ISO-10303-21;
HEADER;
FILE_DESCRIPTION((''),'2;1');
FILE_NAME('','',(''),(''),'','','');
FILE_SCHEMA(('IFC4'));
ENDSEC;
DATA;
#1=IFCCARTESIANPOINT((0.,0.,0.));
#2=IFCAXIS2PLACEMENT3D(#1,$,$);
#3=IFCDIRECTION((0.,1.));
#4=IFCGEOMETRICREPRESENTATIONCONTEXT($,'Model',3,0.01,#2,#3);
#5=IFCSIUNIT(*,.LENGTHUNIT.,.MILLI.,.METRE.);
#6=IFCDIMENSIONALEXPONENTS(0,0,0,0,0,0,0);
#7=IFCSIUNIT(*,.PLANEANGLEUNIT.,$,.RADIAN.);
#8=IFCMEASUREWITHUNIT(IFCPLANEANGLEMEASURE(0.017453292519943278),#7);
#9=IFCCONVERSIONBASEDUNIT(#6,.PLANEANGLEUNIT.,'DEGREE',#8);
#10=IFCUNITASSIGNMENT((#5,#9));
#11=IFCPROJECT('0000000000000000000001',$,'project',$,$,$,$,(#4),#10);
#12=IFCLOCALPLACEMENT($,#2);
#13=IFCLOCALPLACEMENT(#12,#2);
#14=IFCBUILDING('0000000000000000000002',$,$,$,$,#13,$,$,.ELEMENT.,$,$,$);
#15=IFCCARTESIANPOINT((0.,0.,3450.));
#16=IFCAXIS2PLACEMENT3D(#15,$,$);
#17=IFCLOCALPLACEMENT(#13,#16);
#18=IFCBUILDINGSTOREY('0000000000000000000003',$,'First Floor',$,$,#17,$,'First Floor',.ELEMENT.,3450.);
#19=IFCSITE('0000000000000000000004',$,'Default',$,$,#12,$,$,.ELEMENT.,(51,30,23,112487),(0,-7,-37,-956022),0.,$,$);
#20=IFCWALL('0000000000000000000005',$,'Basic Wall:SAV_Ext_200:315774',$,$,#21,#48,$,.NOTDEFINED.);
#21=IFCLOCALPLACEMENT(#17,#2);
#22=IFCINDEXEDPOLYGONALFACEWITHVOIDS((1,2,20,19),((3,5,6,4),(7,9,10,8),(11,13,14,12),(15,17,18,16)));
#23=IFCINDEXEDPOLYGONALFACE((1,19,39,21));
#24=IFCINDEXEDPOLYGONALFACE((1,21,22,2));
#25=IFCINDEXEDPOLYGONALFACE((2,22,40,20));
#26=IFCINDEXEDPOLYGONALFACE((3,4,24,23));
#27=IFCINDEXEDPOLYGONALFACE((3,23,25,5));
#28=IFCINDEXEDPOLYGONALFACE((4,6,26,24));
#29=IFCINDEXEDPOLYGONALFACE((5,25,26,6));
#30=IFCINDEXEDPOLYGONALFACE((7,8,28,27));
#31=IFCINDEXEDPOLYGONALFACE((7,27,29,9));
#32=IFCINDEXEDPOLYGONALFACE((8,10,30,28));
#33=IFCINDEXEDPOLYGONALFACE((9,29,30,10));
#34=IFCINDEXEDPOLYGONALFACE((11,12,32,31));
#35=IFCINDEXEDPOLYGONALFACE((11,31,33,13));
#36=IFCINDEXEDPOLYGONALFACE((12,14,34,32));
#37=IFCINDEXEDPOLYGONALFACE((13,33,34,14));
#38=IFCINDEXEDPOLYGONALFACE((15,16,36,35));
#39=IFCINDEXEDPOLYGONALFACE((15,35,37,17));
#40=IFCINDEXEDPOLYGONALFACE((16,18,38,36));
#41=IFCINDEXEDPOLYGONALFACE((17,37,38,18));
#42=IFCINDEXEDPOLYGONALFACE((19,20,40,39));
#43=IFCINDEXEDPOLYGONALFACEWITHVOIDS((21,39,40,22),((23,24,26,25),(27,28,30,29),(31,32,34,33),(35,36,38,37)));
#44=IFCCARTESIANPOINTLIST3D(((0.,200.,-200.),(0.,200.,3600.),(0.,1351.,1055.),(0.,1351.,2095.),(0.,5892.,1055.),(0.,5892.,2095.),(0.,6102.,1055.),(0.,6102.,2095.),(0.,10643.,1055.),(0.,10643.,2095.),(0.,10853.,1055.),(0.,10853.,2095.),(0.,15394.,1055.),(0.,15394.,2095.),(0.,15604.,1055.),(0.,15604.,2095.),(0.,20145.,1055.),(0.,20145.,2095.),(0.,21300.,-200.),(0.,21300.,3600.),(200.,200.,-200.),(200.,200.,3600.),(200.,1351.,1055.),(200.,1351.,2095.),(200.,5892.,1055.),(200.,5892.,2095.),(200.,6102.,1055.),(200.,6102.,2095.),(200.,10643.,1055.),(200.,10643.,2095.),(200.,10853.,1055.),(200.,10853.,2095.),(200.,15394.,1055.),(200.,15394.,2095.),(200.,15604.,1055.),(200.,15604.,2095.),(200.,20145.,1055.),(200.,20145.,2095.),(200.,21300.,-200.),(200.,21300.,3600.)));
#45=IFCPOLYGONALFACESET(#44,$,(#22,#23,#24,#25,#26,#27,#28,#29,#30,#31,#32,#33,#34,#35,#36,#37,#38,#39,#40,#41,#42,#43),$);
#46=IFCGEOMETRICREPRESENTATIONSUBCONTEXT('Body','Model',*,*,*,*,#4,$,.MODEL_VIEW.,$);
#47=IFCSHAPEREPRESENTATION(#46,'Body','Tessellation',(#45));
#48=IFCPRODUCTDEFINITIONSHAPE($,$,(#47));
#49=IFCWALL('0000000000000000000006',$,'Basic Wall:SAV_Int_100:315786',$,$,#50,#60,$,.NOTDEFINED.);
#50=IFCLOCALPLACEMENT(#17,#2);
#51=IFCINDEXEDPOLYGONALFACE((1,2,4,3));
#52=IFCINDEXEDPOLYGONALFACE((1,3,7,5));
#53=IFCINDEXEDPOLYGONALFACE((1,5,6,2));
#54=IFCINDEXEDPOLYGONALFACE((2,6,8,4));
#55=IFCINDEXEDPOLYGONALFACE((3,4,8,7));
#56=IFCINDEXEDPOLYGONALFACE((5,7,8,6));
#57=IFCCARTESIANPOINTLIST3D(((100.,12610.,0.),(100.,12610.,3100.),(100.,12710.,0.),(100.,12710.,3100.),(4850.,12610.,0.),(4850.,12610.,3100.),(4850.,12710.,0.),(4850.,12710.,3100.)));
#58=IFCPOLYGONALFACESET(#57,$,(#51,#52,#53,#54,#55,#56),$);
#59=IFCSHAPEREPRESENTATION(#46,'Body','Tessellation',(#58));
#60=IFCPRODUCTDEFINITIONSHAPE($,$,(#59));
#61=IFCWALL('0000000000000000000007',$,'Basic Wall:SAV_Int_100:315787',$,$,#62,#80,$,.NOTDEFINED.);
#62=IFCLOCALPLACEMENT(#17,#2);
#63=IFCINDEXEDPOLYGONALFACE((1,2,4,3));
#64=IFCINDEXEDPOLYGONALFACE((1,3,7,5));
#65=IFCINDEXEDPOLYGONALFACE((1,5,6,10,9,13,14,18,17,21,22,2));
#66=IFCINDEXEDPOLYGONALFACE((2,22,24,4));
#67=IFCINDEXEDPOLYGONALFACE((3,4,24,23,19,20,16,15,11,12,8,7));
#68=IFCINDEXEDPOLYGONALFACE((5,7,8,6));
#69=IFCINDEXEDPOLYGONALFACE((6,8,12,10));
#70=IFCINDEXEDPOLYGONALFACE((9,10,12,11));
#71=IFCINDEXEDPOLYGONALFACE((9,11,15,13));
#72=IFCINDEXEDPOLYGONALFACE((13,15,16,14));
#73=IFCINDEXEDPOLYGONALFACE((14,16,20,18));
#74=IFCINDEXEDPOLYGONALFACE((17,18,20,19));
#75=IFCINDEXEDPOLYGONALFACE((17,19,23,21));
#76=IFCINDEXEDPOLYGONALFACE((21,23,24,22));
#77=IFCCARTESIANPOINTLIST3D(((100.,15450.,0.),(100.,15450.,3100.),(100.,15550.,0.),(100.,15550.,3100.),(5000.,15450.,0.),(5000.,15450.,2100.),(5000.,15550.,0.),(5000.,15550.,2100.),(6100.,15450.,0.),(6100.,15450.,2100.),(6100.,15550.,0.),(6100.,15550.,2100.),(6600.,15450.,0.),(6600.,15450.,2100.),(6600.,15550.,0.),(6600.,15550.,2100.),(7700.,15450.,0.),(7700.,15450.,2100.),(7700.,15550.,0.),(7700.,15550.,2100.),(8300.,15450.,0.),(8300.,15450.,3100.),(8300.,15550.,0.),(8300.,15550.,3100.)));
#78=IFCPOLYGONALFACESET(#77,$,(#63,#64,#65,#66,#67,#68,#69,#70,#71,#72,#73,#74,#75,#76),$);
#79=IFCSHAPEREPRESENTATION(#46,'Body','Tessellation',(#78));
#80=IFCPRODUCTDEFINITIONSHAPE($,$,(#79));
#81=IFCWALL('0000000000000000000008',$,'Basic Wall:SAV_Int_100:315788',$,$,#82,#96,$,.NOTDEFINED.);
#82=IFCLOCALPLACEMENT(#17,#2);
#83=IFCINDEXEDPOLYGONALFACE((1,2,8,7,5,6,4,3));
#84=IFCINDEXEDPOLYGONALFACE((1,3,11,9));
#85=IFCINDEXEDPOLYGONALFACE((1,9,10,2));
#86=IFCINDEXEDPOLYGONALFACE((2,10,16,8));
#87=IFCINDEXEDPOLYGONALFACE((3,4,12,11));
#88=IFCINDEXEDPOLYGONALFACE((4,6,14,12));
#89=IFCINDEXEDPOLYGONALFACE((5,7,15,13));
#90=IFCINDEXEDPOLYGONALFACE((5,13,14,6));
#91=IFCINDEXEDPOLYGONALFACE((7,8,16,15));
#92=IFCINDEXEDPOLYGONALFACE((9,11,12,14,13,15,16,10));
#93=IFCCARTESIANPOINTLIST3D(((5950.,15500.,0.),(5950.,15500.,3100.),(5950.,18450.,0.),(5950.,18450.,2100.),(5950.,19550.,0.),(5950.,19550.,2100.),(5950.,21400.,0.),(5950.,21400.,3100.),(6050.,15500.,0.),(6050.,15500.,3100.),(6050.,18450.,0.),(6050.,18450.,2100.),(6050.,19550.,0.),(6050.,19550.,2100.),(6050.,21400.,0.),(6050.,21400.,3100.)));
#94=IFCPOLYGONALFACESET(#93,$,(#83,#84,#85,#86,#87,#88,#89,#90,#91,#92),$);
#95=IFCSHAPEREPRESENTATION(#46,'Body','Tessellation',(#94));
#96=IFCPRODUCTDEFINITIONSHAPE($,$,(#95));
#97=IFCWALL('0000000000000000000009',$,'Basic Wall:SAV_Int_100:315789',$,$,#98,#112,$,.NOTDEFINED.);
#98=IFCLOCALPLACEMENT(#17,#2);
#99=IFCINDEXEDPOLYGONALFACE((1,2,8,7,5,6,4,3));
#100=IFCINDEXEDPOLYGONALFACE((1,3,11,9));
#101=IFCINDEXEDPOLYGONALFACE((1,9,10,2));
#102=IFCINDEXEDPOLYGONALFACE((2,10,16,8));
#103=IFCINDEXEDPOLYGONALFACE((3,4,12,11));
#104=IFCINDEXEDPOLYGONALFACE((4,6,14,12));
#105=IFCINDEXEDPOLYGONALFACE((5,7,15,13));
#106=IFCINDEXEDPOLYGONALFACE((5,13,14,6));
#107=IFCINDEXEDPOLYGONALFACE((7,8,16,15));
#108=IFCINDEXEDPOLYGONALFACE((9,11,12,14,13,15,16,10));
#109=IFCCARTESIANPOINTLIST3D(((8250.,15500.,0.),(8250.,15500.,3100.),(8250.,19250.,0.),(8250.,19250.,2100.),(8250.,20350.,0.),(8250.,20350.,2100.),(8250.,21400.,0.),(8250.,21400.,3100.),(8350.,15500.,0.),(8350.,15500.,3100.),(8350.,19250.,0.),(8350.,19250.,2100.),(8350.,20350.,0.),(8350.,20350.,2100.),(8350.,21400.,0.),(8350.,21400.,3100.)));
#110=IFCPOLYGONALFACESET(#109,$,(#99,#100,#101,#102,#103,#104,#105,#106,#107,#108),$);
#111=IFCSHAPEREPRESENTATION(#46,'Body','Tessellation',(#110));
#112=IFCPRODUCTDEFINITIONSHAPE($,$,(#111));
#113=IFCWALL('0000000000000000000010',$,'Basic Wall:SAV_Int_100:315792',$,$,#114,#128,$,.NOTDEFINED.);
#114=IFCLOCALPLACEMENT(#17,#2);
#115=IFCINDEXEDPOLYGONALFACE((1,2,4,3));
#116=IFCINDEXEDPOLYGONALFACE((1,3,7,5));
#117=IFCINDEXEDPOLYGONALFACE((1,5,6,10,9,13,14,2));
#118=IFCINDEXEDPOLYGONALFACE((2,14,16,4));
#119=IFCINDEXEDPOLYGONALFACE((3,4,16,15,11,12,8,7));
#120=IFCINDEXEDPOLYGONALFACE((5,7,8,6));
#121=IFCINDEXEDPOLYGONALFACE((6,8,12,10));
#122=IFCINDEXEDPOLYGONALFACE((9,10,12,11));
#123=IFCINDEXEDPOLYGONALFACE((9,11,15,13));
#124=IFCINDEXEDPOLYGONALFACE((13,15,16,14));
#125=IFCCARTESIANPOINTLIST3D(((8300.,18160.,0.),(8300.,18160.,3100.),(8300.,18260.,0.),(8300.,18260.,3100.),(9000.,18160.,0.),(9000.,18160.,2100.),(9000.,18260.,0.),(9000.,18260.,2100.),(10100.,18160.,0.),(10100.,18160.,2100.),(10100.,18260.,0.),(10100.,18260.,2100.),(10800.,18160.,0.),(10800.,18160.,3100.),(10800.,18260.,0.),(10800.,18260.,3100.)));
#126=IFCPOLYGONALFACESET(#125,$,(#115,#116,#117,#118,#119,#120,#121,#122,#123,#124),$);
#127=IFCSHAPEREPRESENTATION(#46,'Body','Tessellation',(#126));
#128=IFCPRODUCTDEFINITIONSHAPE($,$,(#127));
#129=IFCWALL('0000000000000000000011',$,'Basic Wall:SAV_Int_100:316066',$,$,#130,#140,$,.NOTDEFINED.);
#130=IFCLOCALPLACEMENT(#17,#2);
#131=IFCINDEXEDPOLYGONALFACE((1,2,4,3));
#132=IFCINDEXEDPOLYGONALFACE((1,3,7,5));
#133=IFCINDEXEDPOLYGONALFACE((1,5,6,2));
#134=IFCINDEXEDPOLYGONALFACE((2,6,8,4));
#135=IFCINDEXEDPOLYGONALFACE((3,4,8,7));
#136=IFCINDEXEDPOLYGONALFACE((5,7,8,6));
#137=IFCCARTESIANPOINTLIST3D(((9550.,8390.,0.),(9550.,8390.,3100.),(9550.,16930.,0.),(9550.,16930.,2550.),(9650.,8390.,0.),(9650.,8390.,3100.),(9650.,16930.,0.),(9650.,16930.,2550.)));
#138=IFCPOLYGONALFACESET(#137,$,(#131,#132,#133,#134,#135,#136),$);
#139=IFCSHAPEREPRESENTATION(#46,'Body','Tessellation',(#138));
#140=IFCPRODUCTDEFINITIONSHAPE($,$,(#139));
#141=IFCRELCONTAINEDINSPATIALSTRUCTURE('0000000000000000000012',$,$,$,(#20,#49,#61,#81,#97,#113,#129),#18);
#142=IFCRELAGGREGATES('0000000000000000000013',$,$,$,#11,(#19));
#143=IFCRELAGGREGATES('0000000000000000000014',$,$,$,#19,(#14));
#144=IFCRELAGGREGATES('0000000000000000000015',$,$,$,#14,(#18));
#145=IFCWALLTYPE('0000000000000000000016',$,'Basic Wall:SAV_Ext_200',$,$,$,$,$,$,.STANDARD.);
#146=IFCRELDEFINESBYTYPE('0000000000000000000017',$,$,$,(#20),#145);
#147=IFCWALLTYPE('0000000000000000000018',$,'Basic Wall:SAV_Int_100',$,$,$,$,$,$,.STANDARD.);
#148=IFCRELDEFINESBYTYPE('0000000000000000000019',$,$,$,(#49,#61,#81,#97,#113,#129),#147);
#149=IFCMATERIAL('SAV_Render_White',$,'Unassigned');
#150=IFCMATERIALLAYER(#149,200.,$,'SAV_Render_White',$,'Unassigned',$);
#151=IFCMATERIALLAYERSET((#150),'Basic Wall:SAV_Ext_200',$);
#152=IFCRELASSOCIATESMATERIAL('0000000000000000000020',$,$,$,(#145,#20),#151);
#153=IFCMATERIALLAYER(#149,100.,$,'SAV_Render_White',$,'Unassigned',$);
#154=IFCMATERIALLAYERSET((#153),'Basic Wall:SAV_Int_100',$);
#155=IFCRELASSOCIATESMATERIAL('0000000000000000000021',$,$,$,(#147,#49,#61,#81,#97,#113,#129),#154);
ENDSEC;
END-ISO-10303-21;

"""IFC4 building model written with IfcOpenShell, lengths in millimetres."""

from ifc_helpers import new_model, entity, si_unit, converted_unit, direction, frame, frame_2d, origin, place, context, subcontext, project, spatial, rectangle, extrude, clip, halfspace, material, layer, layer_set, layer_usage, type_object, element, save


model = new_model("IFC4")

# Units and contexts
model_context = context("Model", 3, precision=0.01, world=origin(), true_north=direction((0.0, 1.0)))
body_context = subcontext(model_context, "Body", "Model", "MODEL_VIEW")
ifc_project = project(units=[si_unit("LENGTHUNIT", "METRE", prefix="MILLI"), converted_unit("PLANEANGLEUNIT", "DEGREE", entity("IfcPlaneAngleMeasure", 0.017453292519943278), si_unit("PLANEANGLEUNIT", "RADIAN"), dimensions=[0, 0, 0, 0, 0, 0, 0])], contexts=[model_context])

# Site, building, storey
site_placement = place(None, origin())
site = spatial("IfcSite", under=ifc_project, at=site_placement, Name="Default", CompositionType="ELEMENT", RefLatitude=(51, 30, 23, 112487), RefLongitude=(0, -7, -37, -956022), RefElevation=0.0)
building_placement = place(site_placement, origin())
building = spatial("IfcBuilding", under=site, at=building_placement, CompositionType="ELEMENT")
storey_placement = place(building_placement, frame((0.0, 0.0, 3450.0)))
storey = spatial("IfcBuildingStorey", under=building, at=storey_placement, Name="First Floor", LongName="First Floor", CompositionType="ELEMENT", Elevation=3450.0)

# Wall, openings
ifc_material_1 = material(Name="SAV_Render_White", Category="Unassigned")
ifc_layer_1 = layer(ifc_material_1, 200.0, Name="SAV_Render_White", Category="Unassigned")
ifc_layer_set_1 = layer_set([ifc_layer_1], Name="Basic Wall:SAV_Ext_200")
ifc_layer_usage_1 = layer_usage(ifc_layer_set_1, "AXIS2", "NEGATIVE", 100.0)
wall_type_1 = type_object("IfcWallType", Name="Basic Wall:SAV_Ext_200", PredefinedType="STANDARD", material=ifc_layer_set_1)
wall_1_placement = place(storey_placement, frame((100.0, 21300.0, -200.0), z_axis=(0.0, 0.0, 1.0), x_axis=(0.0, -1.0, 0.0)))
wall_1 = element("IfcWall", 1, at=wall_1_placement, inside=storey, type_object=wall_type_1, material=ifc_layer_usage_1, Name="Basic Wall:SAV_Ext_200:315774", PredefinedType="NOTDEFINED", context=body_context, shape_type="SweptSolid", body=[
    extrude(rectangle(XDim=21100.0, YDim=200.0, at=frame_2d((10550.0, 0.0), x_axis=(-1.0, 0.0))), origin(), (0.0, 0.0, 1.0), 3800.0),
])
opening_1_placement = place(wall_1_placement, frame((15408.0, -100.0, 1255.0)))
element("IfcOpeningElement", 2, at=opening_1_placement, cuts=wall_1, PredefinedType="OPENING", context=body_context, shape_type="SweptSolid", body=[
    extrude(rectangle(XDim=1040.0, YDim=4541.0, at=frame_2d((520.0, 2270.5), x_axis=(-1.0, 0.0))), frame((0.0, 0.0, 0.0), z_axis=(0.0, 1.0, 0.0), x_axis=(0.0, 0.0, 1.0)), (0.0, 0.0, 1.0), 200.0),
])
opening_2_placement = place(wall_1_placement, frame((10657.0, -100.0, 1255.0)))
element("IfcOpeningElement", 3, at=opening_2_placement, cuts=wall_1, PredefinedType="OPENING", context=body_context, shape_type="SweptSolid", body=[
    extrude(rectangle(XDim=1040.0, YDim=4541.0, at=frame_2d((520.0, 2270.5), x_axis=(-1.0, 0.0))), frame((0.0, 0.0, 0.0), z_axis=(0.0, 1.0, 0.0), x_axis=(0.0, 0.0, 1.0)), (0.0, 0.0, 1.0), 200.0),
])
opening_3_placement = place(wall_1_placement, frame((5906.0, -100.0, 1255.0)))
element("IfcOpeningElement", 4, at=opening_3_placement, cuts=wall_1, PredefinedType="OPENING", context=body_context, shape_type="SweptSolid", body=[
    extrude(rectangle(XDim=1040.0, YDim=4541.0, at=frame_2d((520.0, 2270.5), x_axis=(-1.0, 0.0))), frame((0.0, 0.0, 0.0), z_axis=(0.0, 1.0, 0.0), x_axis=(0.0, 0.0, 1.0)), (0.0, 0.0, 1.0), 200.0),
])
opening_4_placement = place(wall_1_placement, frame((1155.0, -100.0, 1255.0)))
element("IfcOpeningElement", 5, at=opening_4_placement, cuts=wall_1, PredefinedType="OPENING", context=body_context, shape_type="SweptSolid", body=[
    extrude(rectangle(XDim=1040.0, YDim=4541.0, at=frame_2d((520.0, 2270.5), x_axis=(-1.0, 0.0))), frame((0.0, 0.0, 0.0), z_axis=(0.0, 1.0, 0.0), x_axis=(0.0, 0.0, 1.0)), (0.0, 0.0, 1.0), 200.0),
])

# Wall
ifc_layer_2 = layer(ifc_material_1, 100.0, Name="SAV_Render_White", Category="Unassigned")
ifc_layer_set_2 = layer_set([ifc_layer_2], Name="Basic Wall:SAV_Int_100")
ifc_layer_usage_2 = layer_usage(ifc_layer_set_2, "AXIS2", "NEGATIVE", 50.0)
wall_type_2 = type_object("IfcWallType", Name="Basic Wall:SAV_Int_100", PredefinedType="STANDARD", material=ifc_layer_set_2)
wall_2_placement = place(storey_placement, frame((100.0, 12660.0, 0.0)))
element("IfcWall", 6, at=wall_2_placement, inside=storey, type_object=wall_type_2, material=ifc_layer_usage_2, Name="Basic Wall:SAV_Int_100:315786", PredefinedType="NOTDEFINED", context=body_context, shape_type="SweptSolid", body=[
    extrude(rectangle(XDim=4750.0, YDim=100.0, at=frame_2d((2375.0, 0.0), x_axis=(-1.0, 0.0))), origin(), (0.0, 0.0, 1.0), 3100.0),
])

# Wall, openings
ifc_layer_usage_3 = layer_usage(ifc_layer_set_2, "AXIS2", "NEGATIVE", 50.0)
wall_3_placement = place(storey_placement, frame((100.0, 15500.0, 0.0)))
wall_3 = element("IfcWall", 7, at=wall_3_placement, inside=storey, type_object=wall_type_2, material=ifc_layer_usage_3, Name="Basic Wall:SAV_Int_100:315787", PredefinedType="NOTDEFINED", context=body_context, shape_type="SweptSolid", body=[
    extrude(rectangle(XDim=8200.0, YDim=100.0, at=frame_2d((4100.0, 0.0), x_axis=(-1.0, 0.0))), origin(), (0.0, 0.0, 1.0), 3100.0),
])
opening_5_placement = place(wall_3_placement, frame((6500.0, -50.0, 0.0)))
element("IfcOpeningElement", 8, at=opening_5_placement, cuts=wall_3, PredefinedType="OPENING", context=body_context, shape_type="SweptSolid", body=[
    extrude(rectangle(XDim=2100.0, YDim=1100.0, at=frame_2d((1050.0, 550.0), x_axis=(1.0, 0.0))), frame((0.0, 0.0, 0.0), z_axis=(0.0, 1.0, 0.0), x_axis=(0.0, 0.0, 1.0)), (0.0, 0.0, 1.0), 100.0),
])
opening_6_placement = place(wall_3_placement, frame((4900.0, -50.0, 0.0)))
element("IfcOpeningElement", 9, at=opening_6_placement, cuts=wall_3, PredefinedType="OPENING", context=body_context, shape_type="SweptSolid", body=[
    extrude(rectangle(XDim=2100.0, YDim=1100.0, at=frame_2d((1050.0, 550.0), x_axis=(1.0, 0.0))), frame((0.0, 0.0, 0.0), z_axis=(0.0, 1.0, 0.0), x_axis=(0.0, 0.0, 1.0)), (0.0, 0.0, 1.0), 100.0),
])

# Walls, openings
ifc_layer_usage_4 = layer_usage(ifc_layer_set_2, "AXIS2", "NEGATIVE", 50.0)
wall_4_placement = place(storey_placement, frame((6000.0, 15500.0, 0.0), z_axis=(0.0, 0.0, 1.0), x_axis=(0.0, 1.0, 0.0)))
wall_4 = element("IfcWall", 10, at=wall_4_placement, inside=storey, type_object=wall_type_2, material=ifc_layer_usage_4, Name="Basic Wall:SAV_Int_100:315788", PredefinedType="NOTDEFINED", context=body_context, shape_type="SweptSolid", body=[
    extrude(rectangle(XDim=5900.0, YDim=100.0, at=frame_2d((2950.0, 0.0), x_axis=(1.0, 0.0))), origin(), (0.0, 0.0, 1.0), 3100.0),
])
opening_7_placement = place(wall_4_placement, frame((2950.0, -50.0, 0.0)))
element("IfcOpeningElement", 11, at=opening_7_placement, cuts=wall_4, PredefinedType="OPENING", context=body_context, shape_type="SweptSolid", body=[
    extrude(rectangle(XDim=2100.0, YDim=1100.0, at=frame_2d((1050.0, 550.0), x_axis=(1.0, 0.0))), frame((0.0, 0.0, 0.0), z_axis=(0.0, 1.0, 0.0), x_axis=(0.0, 0.0, 1.0)), (0.0, 0.0, 1.0), 100.0),
])
ifc_layer_usage_5 = layer_usage(ifc_layer_set_2, "AXIS2", "NEGATIVE", 50.0)
wall_5_placement = place(storey_placement, frame((8300.0, 15500.0, 0.0), z_axis=(0.0, 0.0, 1.0), x_axis=(0.0, 1.0, 0.0)))
wall_5 = element("IfcWall", 12, at=wall_5_placement, inside=storey, type_object=wall_type_2, material=ifc_layer_usage_5, Name="Basic Wall:SAV_Int_100:315789", PredefinedType="NOTDEFINED", context=body_context, shape_type="SweptSolid", body=[
    extrude(rectangle(XDim=5900.0, YDim=100.0, at=frame_2d((2950.0, 0.0), x_axis=(1.0, 0.0))), origin(), (0.0, 0.0, 1.0), 3100.0),
])
opening_8_placement = place(wall_5_placement, frame((3750.0, -50.0, 0.0)))
element("IfcOpeningElement", 13, at=opening_8_placement, cuts=wall_5, PredefinedType="OPENING", context=body_context, shape_type="SweptSolid", body=[
    extrude(rectangle(XDim=2100.0, YDim=1100.0, at=frame_2d((1050.0, 550.0), x_axis=(1.0, 0.0))), frame((0.0, 0.0, 0.0), z_axis=(0.0, 1.0, 0.0), x_axis=(0.0, 0.0, 1.0)), (0.0, 0.0, 1.0), 100.0),
])
ifc_layer_usage_6 = layer_usage(ifc_layer_set_2, "AXIS2", "NEGATIVE", 50.0)
wall_6_placement = place(storey_placement, frame((8300.0, 18210.0, 0.0)))
wall_6 = element("IfcWall", 14, at=wall_6_placement, inside=storey, type_object=wall_type_2, material=ifc_layer_usage_6, Name="Basic Wall:SAV_Int_100:315792", PredefinedType="NOTDEFINED", context=body_context, shape_type="SweptSolid", body=[
    extrude(rectangle(XDim=2500.0, YDim=100.0, at=frame_2d((1250.0, 0.0), x_axis=(1.0, 0.0))), origin(), (0.0, 0.0, 1.0), 3100.0),
])
opening_9_placement = place(wall_6_placement, frame((700.0, -50.0, 0.0)))
element("IfcOpeningElement", 15, at=opening_9_placement, cuts=wall_6, PredefinedType="OPENING", context=body_context, shape_type="SweptSolid", body=[
    extrude(rectangle(XDim=2100.0, YDim=1100.0, at=frame_2d((1050.0, 550.0), x_axis=(1.0, 0.0))), frame((0.0, 0.0, 0.0), z_axis=(0.0, 1.0, 0.0), x_axis=(0.0, 0.0, 1.0)), (0.0, 0.0, 1.0), 100.0),
])

# Wall
ifc_layer_usage_7 = layer_usage(ifc_layer_set_2, "AXIS2", "POSITIVE", -50.0)
wall_7_placement = place(storey_placement, frame((9600.0, 8390.0, 0.0), z_axis=(0.0, 0.0, 1.0), x_axis=(0.0, 1.0, 0.0)))
element("IfcWall", 16, at=wall_7_placement, inside=storey, type_object=wall_type_2, material=ifc_layer_usage_7, Name="Basic Wall:SAV_Int_100:316066", PredefinedType="NOTDEFINED", context=body_context, shape_type="Clipping", body=[
    clip(extrude(rectangle(XDim=8540.0, YDim=100.0, at=frame_2d((4270.0, 0.0), x_axis=(-1.0, 0.0))), origin(), (0.0, 0.0, 1.0), 3100.0), halfspace(frame((0.0, -50.0, 3100.0), z_axis=(0.06427, 0.0, 0.997933), x_axis=(0.0, 1.0, 0.0)), False)),
])

save(model, "model.ifc")
